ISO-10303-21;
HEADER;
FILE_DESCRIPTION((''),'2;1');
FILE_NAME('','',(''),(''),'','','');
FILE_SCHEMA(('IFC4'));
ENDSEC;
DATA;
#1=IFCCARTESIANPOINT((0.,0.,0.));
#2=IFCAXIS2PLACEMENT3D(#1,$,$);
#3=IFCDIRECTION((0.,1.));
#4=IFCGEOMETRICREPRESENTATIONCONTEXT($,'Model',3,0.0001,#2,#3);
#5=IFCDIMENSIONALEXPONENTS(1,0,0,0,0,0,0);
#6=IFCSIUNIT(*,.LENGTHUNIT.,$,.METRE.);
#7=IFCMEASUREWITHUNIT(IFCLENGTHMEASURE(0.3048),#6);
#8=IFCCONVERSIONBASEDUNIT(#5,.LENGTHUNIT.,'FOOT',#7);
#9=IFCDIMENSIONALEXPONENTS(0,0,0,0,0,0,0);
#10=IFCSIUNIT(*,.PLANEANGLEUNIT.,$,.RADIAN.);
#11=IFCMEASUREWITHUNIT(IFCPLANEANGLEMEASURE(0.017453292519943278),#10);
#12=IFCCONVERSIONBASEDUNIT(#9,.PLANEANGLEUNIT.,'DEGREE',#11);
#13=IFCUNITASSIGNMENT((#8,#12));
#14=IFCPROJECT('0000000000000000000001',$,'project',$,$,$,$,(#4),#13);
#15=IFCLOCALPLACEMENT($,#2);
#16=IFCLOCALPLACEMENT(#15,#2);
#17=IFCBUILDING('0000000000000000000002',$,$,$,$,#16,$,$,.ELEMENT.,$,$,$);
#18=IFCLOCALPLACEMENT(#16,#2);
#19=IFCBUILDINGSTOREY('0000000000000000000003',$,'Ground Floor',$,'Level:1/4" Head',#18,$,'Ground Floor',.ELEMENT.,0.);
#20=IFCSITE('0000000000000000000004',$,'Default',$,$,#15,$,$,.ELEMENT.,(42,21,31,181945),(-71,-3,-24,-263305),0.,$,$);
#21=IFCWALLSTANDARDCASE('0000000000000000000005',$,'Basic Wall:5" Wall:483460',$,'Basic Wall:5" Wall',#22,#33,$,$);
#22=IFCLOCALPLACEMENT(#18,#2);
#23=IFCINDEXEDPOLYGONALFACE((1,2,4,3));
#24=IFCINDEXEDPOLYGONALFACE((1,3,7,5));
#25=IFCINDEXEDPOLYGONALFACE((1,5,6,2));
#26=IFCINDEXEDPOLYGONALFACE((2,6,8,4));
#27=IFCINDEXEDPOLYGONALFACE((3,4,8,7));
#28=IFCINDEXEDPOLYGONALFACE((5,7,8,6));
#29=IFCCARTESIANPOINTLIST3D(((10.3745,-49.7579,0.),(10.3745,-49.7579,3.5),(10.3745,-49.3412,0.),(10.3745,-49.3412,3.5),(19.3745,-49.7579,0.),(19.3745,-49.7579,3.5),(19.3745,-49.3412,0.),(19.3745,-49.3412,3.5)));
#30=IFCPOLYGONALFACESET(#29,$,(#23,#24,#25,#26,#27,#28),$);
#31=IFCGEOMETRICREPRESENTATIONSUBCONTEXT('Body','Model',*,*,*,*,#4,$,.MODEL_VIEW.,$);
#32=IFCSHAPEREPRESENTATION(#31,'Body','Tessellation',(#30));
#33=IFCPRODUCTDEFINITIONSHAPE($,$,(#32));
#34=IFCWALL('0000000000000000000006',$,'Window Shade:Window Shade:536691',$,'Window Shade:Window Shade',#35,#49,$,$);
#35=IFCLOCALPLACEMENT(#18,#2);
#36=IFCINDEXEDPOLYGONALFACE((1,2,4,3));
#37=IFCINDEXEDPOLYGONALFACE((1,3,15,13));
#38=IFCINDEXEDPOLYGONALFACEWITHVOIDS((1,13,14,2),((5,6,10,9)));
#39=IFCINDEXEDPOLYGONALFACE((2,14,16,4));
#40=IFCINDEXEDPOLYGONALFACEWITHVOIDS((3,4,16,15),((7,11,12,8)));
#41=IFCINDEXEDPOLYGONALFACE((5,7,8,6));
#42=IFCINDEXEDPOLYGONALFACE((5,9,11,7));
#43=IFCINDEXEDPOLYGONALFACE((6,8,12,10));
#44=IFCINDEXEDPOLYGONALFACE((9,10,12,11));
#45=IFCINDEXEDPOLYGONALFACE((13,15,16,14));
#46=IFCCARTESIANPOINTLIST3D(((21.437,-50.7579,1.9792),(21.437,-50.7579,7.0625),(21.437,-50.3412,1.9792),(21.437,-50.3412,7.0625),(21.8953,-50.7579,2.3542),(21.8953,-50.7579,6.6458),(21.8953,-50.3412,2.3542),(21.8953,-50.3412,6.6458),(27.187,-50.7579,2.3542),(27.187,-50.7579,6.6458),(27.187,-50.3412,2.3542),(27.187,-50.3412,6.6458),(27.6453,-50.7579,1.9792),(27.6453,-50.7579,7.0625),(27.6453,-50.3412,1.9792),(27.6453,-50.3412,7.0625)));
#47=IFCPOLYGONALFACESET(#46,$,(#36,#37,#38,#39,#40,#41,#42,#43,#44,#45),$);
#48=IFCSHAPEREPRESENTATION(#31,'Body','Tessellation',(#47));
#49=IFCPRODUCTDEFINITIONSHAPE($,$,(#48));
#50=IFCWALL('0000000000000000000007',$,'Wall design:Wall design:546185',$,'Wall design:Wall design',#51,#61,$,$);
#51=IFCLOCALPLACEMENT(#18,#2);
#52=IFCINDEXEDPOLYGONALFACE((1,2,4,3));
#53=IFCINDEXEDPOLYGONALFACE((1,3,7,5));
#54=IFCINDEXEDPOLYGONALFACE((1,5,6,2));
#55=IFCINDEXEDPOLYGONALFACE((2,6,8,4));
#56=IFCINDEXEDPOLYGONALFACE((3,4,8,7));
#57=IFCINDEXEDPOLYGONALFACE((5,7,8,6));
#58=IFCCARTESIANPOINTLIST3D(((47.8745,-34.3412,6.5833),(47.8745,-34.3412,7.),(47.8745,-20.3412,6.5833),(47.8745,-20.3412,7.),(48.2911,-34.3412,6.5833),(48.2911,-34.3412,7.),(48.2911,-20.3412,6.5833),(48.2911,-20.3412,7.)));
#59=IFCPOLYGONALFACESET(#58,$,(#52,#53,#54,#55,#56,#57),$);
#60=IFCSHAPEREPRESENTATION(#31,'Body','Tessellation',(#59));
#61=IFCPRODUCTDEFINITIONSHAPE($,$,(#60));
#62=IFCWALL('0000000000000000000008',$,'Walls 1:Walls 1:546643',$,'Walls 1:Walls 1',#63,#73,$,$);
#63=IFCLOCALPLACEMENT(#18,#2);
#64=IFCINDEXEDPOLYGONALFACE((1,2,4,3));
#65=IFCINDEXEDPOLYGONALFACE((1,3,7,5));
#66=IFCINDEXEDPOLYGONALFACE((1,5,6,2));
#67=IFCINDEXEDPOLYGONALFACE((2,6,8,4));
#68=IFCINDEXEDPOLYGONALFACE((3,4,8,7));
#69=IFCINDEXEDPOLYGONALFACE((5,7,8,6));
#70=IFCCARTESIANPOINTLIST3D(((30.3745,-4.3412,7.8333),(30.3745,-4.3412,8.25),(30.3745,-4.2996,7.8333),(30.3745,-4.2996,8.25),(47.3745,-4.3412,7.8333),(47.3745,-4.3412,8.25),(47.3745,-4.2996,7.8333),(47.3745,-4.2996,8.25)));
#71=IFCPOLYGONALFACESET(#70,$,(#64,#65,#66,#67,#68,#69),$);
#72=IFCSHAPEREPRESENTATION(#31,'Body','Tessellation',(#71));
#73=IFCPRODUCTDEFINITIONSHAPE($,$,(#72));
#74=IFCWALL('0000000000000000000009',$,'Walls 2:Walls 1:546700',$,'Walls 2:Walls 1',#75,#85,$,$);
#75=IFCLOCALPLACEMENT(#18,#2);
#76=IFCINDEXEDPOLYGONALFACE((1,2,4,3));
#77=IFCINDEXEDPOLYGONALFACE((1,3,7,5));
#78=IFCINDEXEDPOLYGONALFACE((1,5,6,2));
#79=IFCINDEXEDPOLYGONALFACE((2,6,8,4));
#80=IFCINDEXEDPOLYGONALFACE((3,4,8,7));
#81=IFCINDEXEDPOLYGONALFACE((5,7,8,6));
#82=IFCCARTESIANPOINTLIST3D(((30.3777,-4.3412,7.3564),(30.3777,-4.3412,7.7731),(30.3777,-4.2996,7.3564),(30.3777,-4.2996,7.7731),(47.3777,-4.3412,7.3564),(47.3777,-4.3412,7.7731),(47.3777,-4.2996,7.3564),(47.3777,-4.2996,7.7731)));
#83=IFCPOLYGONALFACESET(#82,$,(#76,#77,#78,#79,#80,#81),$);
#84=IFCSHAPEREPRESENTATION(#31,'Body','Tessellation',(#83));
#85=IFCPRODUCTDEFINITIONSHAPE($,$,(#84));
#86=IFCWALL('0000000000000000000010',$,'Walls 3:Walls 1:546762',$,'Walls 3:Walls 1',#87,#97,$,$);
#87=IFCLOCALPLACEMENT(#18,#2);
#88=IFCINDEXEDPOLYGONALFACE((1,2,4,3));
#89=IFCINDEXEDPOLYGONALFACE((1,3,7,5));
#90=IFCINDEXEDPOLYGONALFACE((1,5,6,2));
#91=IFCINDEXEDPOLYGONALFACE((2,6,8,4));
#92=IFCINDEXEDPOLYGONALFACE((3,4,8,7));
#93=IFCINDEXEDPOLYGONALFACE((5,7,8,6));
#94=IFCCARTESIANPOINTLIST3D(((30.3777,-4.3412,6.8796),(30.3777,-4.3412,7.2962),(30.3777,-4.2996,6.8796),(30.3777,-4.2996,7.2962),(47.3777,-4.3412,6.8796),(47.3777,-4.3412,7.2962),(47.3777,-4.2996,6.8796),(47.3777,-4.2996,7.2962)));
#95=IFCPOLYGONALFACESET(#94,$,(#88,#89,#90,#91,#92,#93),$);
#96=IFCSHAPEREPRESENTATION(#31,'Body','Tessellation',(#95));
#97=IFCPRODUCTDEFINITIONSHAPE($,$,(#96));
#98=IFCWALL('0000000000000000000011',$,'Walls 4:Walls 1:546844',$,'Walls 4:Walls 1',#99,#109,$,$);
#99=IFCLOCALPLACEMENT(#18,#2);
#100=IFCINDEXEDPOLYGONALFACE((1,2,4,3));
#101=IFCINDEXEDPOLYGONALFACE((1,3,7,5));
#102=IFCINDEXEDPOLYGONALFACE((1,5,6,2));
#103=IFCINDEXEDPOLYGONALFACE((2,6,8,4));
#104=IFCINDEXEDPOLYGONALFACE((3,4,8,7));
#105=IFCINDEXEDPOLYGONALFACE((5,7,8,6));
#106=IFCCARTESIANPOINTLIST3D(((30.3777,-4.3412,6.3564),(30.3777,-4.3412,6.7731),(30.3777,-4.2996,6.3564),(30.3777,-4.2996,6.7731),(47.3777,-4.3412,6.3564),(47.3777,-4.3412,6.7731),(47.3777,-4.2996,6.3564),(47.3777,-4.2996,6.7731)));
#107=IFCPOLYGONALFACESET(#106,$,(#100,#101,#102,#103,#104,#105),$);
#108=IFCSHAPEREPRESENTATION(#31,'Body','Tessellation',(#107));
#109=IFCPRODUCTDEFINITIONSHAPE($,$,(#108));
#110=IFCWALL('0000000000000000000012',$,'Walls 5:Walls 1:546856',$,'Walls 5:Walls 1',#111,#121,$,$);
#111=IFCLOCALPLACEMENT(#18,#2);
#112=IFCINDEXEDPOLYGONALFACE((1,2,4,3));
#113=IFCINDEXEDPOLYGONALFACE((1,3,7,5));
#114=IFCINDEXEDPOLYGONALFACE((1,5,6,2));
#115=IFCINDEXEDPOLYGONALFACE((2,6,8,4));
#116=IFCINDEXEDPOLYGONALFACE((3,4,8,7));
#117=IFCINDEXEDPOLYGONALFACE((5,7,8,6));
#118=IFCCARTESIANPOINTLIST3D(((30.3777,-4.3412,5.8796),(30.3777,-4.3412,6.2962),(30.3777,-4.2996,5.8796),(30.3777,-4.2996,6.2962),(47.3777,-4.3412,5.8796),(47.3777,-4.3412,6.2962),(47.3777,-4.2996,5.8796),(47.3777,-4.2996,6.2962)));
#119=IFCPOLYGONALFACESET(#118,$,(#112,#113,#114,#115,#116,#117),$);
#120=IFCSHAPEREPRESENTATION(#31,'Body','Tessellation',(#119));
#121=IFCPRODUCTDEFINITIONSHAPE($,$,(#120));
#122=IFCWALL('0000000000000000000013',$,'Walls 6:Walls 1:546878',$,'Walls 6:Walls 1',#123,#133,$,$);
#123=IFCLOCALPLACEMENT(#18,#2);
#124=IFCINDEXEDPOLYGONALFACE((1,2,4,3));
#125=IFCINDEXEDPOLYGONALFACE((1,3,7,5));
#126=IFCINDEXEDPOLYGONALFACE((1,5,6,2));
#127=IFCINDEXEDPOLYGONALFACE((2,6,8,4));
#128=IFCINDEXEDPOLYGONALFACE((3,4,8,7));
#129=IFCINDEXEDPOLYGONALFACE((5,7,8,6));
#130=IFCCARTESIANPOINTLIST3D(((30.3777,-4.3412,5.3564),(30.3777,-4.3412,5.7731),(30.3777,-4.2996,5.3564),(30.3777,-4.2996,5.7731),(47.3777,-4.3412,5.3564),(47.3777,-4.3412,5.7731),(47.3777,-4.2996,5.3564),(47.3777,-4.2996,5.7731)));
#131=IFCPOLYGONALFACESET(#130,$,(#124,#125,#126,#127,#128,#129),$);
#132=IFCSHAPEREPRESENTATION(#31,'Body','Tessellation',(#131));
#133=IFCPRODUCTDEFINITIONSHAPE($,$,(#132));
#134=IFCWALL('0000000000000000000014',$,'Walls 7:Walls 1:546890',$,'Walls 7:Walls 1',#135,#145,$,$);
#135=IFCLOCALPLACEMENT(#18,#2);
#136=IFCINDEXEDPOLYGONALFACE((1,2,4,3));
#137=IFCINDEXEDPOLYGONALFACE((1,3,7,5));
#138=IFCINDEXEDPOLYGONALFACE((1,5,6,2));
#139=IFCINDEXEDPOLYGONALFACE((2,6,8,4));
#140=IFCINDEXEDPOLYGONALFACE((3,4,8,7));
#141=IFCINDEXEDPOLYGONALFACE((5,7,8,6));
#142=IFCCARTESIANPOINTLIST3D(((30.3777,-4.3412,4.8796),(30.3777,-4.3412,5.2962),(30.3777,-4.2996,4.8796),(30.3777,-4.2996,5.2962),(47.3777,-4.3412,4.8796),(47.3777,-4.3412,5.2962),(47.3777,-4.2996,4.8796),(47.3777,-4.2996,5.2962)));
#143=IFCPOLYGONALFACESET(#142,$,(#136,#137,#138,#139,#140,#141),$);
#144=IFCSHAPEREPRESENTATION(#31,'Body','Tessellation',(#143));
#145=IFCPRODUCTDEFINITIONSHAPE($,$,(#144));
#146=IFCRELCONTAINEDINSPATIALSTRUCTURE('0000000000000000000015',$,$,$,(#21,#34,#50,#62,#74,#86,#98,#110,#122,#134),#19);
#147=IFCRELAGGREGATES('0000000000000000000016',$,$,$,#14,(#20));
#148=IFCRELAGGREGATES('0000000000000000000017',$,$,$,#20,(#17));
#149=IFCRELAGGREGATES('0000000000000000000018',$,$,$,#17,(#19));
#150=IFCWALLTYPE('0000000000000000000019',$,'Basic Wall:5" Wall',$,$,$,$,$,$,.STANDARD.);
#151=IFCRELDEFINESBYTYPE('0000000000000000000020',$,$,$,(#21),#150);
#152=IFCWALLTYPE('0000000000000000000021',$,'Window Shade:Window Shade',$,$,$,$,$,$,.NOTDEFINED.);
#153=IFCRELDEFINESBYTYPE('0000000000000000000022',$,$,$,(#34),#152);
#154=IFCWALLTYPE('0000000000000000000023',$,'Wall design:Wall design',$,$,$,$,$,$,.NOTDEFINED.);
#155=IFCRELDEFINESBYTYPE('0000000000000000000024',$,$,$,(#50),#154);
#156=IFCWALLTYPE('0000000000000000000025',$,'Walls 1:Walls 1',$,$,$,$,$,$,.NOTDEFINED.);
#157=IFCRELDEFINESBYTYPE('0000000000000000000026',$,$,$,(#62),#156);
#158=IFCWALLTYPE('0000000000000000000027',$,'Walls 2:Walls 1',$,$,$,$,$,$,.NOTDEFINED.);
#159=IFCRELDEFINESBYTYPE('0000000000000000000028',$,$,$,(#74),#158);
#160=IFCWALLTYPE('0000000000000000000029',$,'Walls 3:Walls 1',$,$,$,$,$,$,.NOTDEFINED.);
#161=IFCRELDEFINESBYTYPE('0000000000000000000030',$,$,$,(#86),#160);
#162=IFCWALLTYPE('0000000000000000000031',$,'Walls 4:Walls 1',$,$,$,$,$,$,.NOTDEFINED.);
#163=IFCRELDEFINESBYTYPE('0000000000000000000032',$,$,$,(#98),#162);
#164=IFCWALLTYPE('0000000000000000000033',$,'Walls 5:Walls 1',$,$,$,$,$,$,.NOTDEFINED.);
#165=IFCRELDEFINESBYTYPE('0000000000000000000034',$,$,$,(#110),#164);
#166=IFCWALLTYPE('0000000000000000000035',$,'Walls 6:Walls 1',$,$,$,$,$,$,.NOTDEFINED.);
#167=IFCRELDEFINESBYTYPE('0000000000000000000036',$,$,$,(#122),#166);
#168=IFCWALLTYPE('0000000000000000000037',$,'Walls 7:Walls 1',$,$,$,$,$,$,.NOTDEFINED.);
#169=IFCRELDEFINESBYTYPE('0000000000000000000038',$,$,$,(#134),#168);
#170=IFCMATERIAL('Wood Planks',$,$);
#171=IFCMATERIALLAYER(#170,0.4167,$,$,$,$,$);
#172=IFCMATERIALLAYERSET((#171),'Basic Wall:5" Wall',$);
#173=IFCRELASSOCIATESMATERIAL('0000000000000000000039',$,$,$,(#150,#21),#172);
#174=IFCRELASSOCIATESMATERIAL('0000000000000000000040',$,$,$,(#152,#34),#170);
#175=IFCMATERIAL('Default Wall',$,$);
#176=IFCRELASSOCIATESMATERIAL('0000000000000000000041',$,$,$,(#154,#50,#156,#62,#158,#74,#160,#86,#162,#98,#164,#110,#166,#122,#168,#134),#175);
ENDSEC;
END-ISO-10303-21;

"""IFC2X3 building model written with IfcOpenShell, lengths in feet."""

from ifc_helpers import new_model, entity, si_unit, converted_unit, direction, frame, frame_2d, origin, place, context, subcontext, project, spatial, rectangle, extrude, material, layer, layer_set, layer_usage, type_object, element, save


model = new_model("IFC2X3")

# Units and contexts
model_context = context("Model", 3, precision=0.0001, world=origin(), true_north=direction((0.0, 1.0)))
body_context = subcontext(model_context, "Body", "Model", "MODEL_VIEW")
ifc_project = project(units=[converted_unit("LENGTHUNIT", "FOOT", entity("IfcLengthMeasure", 0.3048), si_unit("LENGTHUNIT", "METRE"), dimensions=[1, 0, 0, 0, 0, 0, 0]), converted_unit("PLANEANGLEUNIT", "DEGREE", entity("IfcPlaneAngleMeasure", 0.017453292519943278), si_unit("PLANEANGLEUNIT", "RADIAN"), dimensions=[0, 0, 0, 0, 0, 0, 0])], contexts=[model_context])

# Site, building, storey
site_placement = place(None, origin())
site = spatial("IfcSite", under=ifc_project, at=site_placement, Name="Default", CompositionType="ELEMENT", RefLatitude=(42, 21, 31, 181945), RefLongitude=(-71, -3, -24, -263305), RefElevation=0.0)
building_placement = place(site_placement, origin())
building = spatial("IfcBuilding", under=site, at=building_placement, CompositionType="ELEMENT")
storey_placement = place(building_placement, origin())
storey = spatial("IfcBuildingStorey", under=building, at=storey_placement, Name="Ground Floor", ObjectType="Level:1/4\" Head", LongName="Ground Floor", CompositionType="ELEMENT", Elevation=0.0)

# Shared definitions
ifc_material_1 = material(Name="Default Wall")

# Shared definitions
ifc_material_2 = material(Name="Wood Planks")
ifc_layer_1 = layer(ifc_material_2, 0.4167)
ifc_layer_set_1 = layer_set([ifc_layer_1], Name="Basic Wall:5\" Wall")
ifc_layer_usage_1 = layer_usage(ifc_layer_set_1, "AXIS2", "NEGATIVE", 0.2083)
wall_type_1 = type_object("IfcWallType", Name="Basic Wall:5\" Wall", PredefinedType="STANDARD", material=ifc_layer_set_1)

# Wall
wall_1_placement = place(storey_placement, frame((10.3745, -49.5496, 0.0)))
element("IfcWallStandardCase", 1, at=wall_1_placement, inside=storey, type_object=wall_type_1, material=ifc_layer_usage_1, Name="Basic Wall:5\" Wall:483460", ObjectType="Basic Wall:5\" Wall", context=body_context, shape_type="SweptSolid", body=[
    extrude(rectangle(XDim=9.0, YDim=0.4167, at=frame_2d((4.5, 0.0), x_axis=(-1.0, 0.0))), origin(), (0.0, 0.0, 1.0), 3.5),
])

# Wall, opening
wall_type_2 = type_object("IfcWallType", Name="Window Shade:Window Shade", PredefinedType="NOTDEFINED", material=ifc_material_2)
wall_2_placement = place(storey_placement, frame((21.437, -50.7579, 1.9792)))
wall_2 = element("IfcWall", 2, at=wall_2_placement, inside=storey, type_object=wall_type_2, material=ifc_material_2, Name="Window Shade:Window Shade:536691", ObjectType="Window Shade:Window Shade", context=body_context, shape_type="SweptSolid", body=[
    extrude(rectangle(XDim=0.4167, YDim=6.2083, at=frame_2d((0.0, 0.0), x_axis=(1.0, 0.0))), frame((3.1042, 0.2083, 0.0), z_axis=(0.0, 0.0, 1.0), x_axis=(0.0, 1.0, 0.0)), (0.0, 0.0, 1.0), 5.0833),
])
opening_1_placement = place(storey_placement, frame((21.437, -50.7579, 1.9792)))
element("IfcOpeningElement", 3, at=opening_1_placement, cuts=wall_2, ObjectType="Opening", context=body_context, shape_type="SweptSolid", body=[
    extrude(rectangle(XDim=4.2917, YDim=5.2917, at=frame_2d((0.0, 0.0), x_axis=(0.0, 1.0))), frame((3.1042, 0.4167, 2.5208), z_axis=(0.0, -1.0, 0.0), x_axis=(-1.0, 0.0, 0.0)), (0.0, 0.0, 1.0), 0.4167),
])

# Walls
wall_type_3 = type_object("IfcWallType", Name="Wall design:Wall design", PredefinedType="NOTDEFINED", material=ifc_material_1)
wall_3_placement = place(storey_placement, frame((47.8745, -34.3412, 6.5833), z_axis=(0.0, 0.0, 1.0), x_axis=(0.0, 1.0, 0.0)))
element("IfcWall", 4, at=wall_3_placement, inside=storey, type_object=wall_type_3, material=ifc_material_1, Name="Wall design:Wall design:546185", ObjectType="Wall design:Wall design", context=body_context, shape_type="SweptSolid", body=[
    extrude(rectangle(XDim=0.4167, YDim=14.0, at=frame_2d((0.0, 0.0), x_axis=(1.0, 0.0))), frame((7.0, -0.2083, 0.0), z_axis=(0.0, 0.0, 1.0), x_axis=(0.0, 1.0, 0.0)), (0.0, 0.0, 1.0), 0.4167),
])
wall_type_4 = type_object("IfcWallType", Name="Walls 1:Walls 1", PredefinedType="NOTDEFINED", material=ifc_material_1)
wall_4_placement = place(storey_placement, frame((30.3745, -4.3412, 7.8333)))
element("IfcWall", 5, at=wall_4_placement, inside=storey, type_object=wall_type_4, material=ifc_material_1, Name="Walls 1:Walls 1:546643", ObjectType="Walls 1:Walls 1", context=body_context, shape_type="SweptSolid", body=[
    extrude(rectangle(XDim=0.0417, YDim=17.0, at=frame_2d((0.0, 0.0), x_axis=(1.0, 0.0))), frame((8.5, 0.0208, 0.0), z_axis=(0.0, 0.0, 1.0), x_axis=(0.0, -1.0, 0.0)), (0.0, 0.0, 1.0), 0.4167),
])
wall_type_5 = type_object("IfcWallType", Name="Walls 2:Walls 1", PredefinedType="NOTDEFINED", material=ifc_material_1)
wall_5_placement = place(storey_placement, frame((30.3777, -4.3412, 7.3564)))
element("IfcWall", 6, at=wall_5_placement, inside=storey, type_object=wall_type_5, material=ifc_material_1, Name="Walls 2:Walls 1:546700", ObjectType="Walls 2:Walls 1", context=body_context, shape_type="SweptSolid", body=[
    extrude(rectangle(XDim=0.0417, YDim=17.0, at=frame_2d((0.0, 0.0), x_axis=(1.0, 0.0))), frame((8.5, 0.0208, 0.0), z_axis=(0.0, 0.0, 1.0), x_axis=(0.0, -1.0, 0.0)), (0.0, 0.0, 1.0), 0.4167),
])
wall_type_6 = type_object("IfcWallType", Name="Walls 3:Walls 1", PredefinedType="NOTDEFINED", material=ifc_material_1)
wall_6_placement = place(storey_placement, frame((30.3777, -4.3412, 6.8796)))
element("IfcWall", 7, at=wall_6_placement, inside=storey, type_object=wall_type_6, material=ifc_material_1, Name="Walls 3:Walls 1:546762", ObjectType="Walls 3:Walls 1", context=body_context, shape_type="SweptSolid", body=[
    extrude(rectangle(XDim=0.0417, YDim=17.0, at=frame_2d((0.0, 0.0), x_axis=(1.0, 0.0))), frame((8.5, 0.0208, 0.0), z_axis=(0.0, 0.0, 1.0), x_axis=(0.0, -1.0, 0.0)), (0.0, 0.0, 1.0), 0.4167),
])
wall_type_7 = type_object("IfcWallType", Name="Walls 4:Walls 1", PredefinedType="NOTDEFINED", material=ifc_material_1)
wall_7_placement = place(storey_placement, frame((30.3777, -4.3412, 6.3564)))
element("IfcWall", 8, at=wall_7_placement, inside=storey, type_object=wall_type_7, material=ifc_material_1, Name="Walls 4:Walls 1:546844", ObjectType="Walls 4:Walls 1", context=body_context, shape_type="SweptSolid", body=[
    extrude(rectangle(XDim=0.0417, YDim=17.0, at=frame_2d((0.0, 0.0), x_axis=(1.0, 0.0))), frame((8.5, 0.0208, 0.0), z_axis=(0.0, 0.0, 1.0), x_axis=(0.0, -1.0, 0.0)), (0.0, 0.0, 1.0), 0.4167),
])
wall_type_8 = type_object("IfcWallType", Name="Walls 5:Walls 1", PredefinedType="NOTDEFINED", material=ifc_material_1)
wall_8_placement = place(storey_placement, frame((30.3777, -4.3412, 5.8796)))
element("IfcWall", 9, at=wall_8_placement, inside=storey, type_object=wall_type_8, material=ifc_material_1, Name="Walls 5:Walls 1:546856", ObjectType="Walls 5:Walls 1", context=body_context, shape_type="SweptSolid", body=[
    extrude(rectangle(XDim=0.0417, YDim=17.0, at=frame_2d((0.0, 0.0), x_axis=(1.0, 0.0))), frame((8.5, 0.0208, 0.0), z_axis=(0.0, 0.0, 1.0), x_axis=(0.0, -1.0, 0.0)), (0.0, 0.0, 1.0), 0.4167),
])
wall_type_9 = type_object("IfcWallType", Name="Walls 6:Walls 1", PredefinedType="NOTDEFINED", material=ifc_material_1)
wall_9_placement = place(storey_placement, frame((30.3777, -4.3412, 5.3564)))
element("IfcWall", 10, at=wall_9_placement, inside=storey, type_object=wall_type_9, material=ifc_material_1, Name="Walls 6:Walls 1:546878", ObjectType="Walls 6:Walls 1", context=body_context, shape_type="SweptSolid", body=[
    extrude(rectangle(XDim=0.0417, YDim=17.0, at=frame_2d((0.0, 0.0), x_axis=(1.0, 0.0))), frame((8.5, 0.0208, 0.0), z_axis=(0.0, 0.0, 1.0), x_axis=(0.0, -1.0, 0.0)), (0.0, 0.0, 1.0), 0.4167),
])
wall_type_10 = type_object("IfcWallType", Name="Walls 7:Walls 1", PredefinedType="NOTDEFINED", material=ifc_material_1)
wall_10_placement = place(storey_placement, frame((30.3777, -4.3412, 4.8796)))
element("IfcWall", 11, at=wall_10_placement, inside=storey, type_object=wall_type_10, material=ifc_material_1, Name="Walls 7:Walls 1:546890", ObjectType="Walls 7:Walls 1", context=body_context, shape_type="SweptSolid", body=[
    extrude(rectangle(XDim=0.0417, YDim=17.0, at=frame_2d((0.0, 0.0), x_axis=(1.0, 0.0))), frame((8.5, 0.0208, 0.0), z_axis=(0.0, 0.0, 1.0), x_axis=(0.0, -1.0, 0.0)), (0.0, 0.0, 1.0), 0.4167),
])

save(model, "model.ifc")
